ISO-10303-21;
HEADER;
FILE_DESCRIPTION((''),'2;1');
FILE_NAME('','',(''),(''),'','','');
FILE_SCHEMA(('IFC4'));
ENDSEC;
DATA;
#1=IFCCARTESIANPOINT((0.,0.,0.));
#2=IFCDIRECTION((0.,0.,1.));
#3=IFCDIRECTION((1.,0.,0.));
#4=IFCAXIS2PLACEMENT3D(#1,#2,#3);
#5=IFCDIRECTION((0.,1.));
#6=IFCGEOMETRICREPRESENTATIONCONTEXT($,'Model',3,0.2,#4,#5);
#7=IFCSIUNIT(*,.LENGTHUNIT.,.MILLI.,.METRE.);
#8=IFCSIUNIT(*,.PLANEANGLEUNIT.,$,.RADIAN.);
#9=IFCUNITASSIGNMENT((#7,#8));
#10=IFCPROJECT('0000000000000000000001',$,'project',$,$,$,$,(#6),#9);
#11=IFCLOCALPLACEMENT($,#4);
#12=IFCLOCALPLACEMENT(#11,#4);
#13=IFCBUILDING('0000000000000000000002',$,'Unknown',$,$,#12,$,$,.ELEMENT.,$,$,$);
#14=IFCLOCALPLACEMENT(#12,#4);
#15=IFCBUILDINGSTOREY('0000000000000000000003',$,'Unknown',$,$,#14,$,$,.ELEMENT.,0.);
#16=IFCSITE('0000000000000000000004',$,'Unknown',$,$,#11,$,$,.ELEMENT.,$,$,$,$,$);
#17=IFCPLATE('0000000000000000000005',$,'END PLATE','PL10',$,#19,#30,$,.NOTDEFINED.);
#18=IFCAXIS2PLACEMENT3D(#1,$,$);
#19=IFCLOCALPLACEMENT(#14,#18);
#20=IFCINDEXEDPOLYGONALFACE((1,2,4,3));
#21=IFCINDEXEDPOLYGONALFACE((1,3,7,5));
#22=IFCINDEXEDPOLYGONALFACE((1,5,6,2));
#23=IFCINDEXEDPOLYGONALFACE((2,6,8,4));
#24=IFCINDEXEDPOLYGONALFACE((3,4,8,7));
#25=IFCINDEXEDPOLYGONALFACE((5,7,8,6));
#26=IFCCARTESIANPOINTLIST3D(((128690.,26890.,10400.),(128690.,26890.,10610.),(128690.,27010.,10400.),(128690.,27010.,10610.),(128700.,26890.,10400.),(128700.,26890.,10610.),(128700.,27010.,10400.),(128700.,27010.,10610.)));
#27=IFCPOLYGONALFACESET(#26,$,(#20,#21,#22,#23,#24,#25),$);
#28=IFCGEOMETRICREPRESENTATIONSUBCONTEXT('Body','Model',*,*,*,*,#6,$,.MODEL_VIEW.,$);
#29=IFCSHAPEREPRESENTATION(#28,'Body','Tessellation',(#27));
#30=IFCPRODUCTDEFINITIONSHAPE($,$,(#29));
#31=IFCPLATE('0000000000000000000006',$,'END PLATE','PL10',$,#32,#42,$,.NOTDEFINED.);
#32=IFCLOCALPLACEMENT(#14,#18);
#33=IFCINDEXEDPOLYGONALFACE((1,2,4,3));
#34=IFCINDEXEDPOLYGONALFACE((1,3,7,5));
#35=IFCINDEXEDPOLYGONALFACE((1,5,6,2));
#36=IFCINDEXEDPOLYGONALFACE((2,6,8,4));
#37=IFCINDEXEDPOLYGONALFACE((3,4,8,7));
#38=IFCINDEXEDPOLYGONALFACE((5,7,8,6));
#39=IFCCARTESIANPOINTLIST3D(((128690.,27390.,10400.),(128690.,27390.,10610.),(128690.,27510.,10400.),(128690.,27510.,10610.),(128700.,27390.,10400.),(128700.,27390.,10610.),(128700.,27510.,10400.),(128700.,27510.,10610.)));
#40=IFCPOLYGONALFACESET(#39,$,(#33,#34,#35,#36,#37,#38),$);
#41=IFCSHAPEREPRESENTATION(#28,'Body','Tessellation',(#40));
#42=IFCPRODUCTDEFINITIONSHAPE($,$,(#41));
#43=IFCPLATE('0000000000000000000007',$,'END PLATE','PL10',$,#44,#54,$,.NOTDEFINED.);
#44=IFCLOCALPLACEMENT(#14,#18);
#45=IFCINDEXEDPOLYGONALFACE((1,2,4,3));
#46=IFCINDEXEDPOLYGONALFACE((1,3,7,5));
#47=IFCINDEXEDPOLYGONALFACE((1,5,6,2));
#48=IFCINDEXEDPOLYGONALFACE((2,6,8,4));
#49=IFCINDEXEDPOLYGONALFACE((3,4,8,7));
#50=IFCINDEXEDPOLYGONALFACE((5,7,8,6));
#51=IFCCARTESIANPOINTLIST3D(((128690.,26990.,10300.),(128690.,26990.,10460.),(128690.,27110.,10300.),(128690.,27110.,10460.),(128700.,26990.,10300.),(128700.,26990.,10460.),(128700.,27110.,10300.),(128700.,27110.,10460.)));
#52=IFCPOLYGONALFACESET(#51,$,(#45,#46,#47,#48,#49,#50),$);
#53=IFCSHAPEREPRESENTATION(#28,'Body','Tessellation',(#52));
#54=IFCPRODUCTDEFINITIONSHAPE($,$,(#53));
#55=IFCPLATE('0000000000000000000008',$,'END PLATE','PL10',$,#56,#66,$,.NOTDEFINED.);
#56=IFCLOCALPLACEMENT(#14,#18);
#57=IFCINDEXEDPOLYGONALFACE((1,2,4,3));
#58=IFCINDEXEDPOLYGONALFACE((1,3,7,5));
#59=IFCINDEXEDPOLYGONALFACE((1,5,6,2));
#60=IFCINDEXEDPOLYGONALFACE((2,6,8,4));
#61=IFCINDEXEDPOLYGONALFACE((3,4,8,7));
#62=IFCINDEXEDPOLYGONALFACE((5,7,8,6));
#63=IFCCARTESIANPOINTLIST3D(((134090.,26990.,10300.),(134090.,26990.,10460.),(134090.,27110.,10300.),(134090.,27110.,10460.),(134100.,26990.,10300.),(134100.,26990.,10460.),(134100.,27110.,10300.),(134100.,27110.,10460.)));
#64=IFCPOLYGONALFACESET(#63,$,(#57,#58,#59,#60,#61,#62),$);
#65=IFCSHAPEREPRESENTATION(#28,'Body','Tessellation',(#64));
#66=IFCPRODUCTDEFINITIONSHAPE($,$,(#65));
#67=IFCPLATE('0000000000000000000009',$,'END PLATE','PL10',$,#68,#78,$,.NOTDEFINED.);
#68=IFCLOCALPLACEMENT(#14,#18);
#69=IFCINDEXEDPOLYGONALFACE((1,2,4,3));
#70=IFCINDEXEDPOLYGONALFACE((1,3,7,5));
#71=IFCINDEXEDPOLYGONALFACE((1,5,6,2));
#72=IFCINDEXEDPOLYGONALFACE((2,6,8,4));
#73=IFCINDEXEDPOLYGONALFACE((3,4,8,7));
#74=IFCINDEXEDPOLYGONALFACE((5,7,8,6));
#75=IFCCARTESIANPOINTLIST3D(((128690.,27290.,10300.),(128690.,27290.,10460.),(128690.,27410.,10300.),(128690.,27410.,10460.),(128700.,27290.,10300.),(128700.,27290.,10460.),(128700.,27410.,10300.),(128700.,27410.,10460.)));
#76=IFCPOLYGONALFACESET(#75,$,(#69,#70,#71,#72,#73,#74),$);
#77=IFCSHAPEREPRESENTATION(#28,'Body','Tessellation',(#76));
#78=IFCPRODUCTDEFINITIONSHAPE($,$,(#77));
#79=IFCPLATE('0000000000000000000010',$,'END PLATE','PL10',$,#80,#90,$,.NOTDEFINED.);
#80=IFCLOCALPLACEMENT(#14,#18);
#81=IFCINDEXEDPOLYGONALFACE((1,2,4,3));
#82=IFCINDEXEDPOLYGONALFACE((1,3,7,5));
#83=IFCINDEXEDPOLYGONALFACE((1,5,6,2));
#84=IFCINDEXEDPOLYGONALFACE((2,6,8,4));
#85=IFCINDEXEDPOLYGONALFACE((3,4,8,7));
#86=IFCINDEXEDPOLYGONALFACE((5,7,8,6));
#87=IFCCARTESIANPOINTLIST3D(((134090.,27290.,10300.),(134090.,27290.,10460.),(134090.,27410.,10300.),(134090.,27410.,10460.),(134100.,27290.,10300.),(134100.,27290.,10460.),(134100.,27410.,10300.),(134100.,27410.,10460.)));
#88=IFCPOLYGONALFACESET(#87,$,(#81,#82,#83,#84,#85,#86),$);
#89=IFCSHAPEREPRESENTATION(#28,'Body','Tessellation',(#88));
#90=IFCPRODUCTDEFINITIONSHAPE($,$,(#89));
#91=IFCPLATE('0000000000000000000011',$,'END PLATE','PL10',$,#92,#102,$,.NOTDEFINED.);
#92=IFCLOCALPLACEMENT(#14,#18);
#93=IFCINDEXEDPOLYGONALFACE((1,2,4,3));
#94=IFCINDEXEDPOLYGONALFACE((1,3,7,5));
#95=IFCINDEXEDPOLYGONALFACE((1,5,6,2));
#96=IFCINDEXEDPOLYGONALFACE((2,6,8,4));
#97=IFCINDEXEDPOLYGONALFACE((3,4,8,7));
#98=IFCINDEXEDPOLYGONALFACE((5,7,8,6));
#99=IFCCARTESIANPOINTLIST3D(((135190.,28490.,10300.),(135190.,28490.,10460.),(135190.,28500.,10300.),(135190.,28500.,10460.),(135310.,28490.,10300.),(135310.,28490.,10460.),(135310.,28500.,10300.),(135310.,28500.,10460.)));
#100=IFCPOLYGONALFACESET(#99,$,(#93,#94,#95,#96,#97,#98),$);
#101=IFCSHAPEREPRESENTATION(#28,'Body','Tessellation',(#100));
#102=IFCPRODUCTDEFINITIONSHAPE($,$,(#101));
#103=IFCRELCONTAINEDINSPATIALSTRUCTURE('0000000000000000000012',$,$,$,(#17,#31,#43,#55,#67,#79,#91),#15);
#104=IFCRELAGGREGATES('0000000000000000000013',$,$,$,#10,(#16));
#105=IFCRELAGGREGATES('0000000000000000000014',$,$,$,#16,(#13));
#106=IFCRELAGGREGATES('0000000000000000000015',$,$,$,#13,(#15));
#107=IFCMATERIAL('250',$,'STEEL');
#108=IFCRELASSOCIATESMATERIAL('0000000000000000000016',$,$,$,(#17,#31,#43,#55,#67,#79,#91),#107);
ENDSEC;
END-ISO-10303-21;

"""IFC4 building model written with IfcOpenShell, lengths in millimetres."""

from ifc_helpers import new_model, si_unit, direction, frame, origin_with_axes, place, context, subcontext, project, spatial, line, indexed_curve, outline, extrude, material, element, save


model = new_model("IFC4")

# Units and contexts
model_context = context("Model", 3, precision=0.2, world=origin_with_axes(), true_north=direction((0.0, 1.0)))
body_context = subcontext(model_context, "Body", "Model", "MODEL_VIEW")
ifc_project = project(units=[si_unit("LENGTHUNIT", "METRE", prefix="MILLI"), si_unit("PLANEANGLEUNIT", "RADIAN")], contexts=[model_context])

# Site, building, storey
site_placement = place(None, origin_with_axes())
site = spatial("IfcSite", under=ifc_project, at=site_placement, Name="Unknown", CompositionType="ELEMENT")
building_placement = place(site_placement, origin_with_axes())
building = spatial("IfcBuilding", under=site, at=building_placement, Name="Unknown", CompositionType="ELEMENT")
storey_placement = place(building_placement, origin_with_axes())
storey = spatial("IfcBuildingStorey", under=building, at=storey_placement, Name="Unknown", CompositionType="ELEMENT", Elevation=0.0)

# Plates
ifc_material_1 = material(Name="250", Category="STEEL")
for number, where, z_axis, x_axis, name in (
    (1, (128695.0, 27010.0, 10400.0), (-1.0, 0.0, 0.0), (0.0, -1.0, 0.0), "END PLATE"),
    (2, (128695.0, 27510.0, 10400.0), (-1.0, 0.0, 0.0), (0.0, -1.0, 0.0), "END PLATE"),
):
    element("IfcPlate", number, at=place(storey_placement, frame(where, z_axis=z_axis, x_axis=x_axis)), inside=storey, material=ifc_material_1, Name=name, Description="PL10", PredefinedType="NOTDEFINED", context=body_context, shape_type="SolidModel", body=[
        extrude(outline(indexed_curve([(0.0, 0.0), (120.0, 0.0), (120.0, 210.0), (0.0, 210.0)], segments=[line(1, 2, 3, 4, 1)])), frame((0.0, 0.0, 5.0), z_axis=(0.0, 0.0, 1.0), x_axis=(1.0, 0.0, 0.0)), (0.0, 0.0, -1.0), 10.0),
    ])
for number, where, z_axis, x_axis, name in (
    (3, (128695.0, 27110.0, 10300.0), (-1.0, 0.0, 0.0), (0.0, -1.0, 0.0), "END PLATE"),
    (4, (134095.0, 27110.0, 10300.0), (-1.0, 0.0, 0.0), (0.0, -1.0, 0.0), "END PLATE"),
    (5, (128695.0, 27410.0, 10300.0), (-1.0, 0.0, 0.0), (0.0, -1.0, 0.0), "END PLATE"),
    (6, (134095.0, 27410.0, 10300.0), (-1.0, 0.0, 0.0), (0.0, -1.0, 0.0), "END PLATE"),
    (7, (135190.0, 28495.0, 10300.0), (0.0, -1.0, 0.0), (1.0, 0.0, 0.0), "END PLATE"),
):
    element("IfcPlate", number, at=place(storey_placement, frame(where, z_axis=z_axis, x_axis=x_axis)), inside=storey, material=ifc_material_1, Name=name, Description="PL10", PredefinedType="NOTDEFINED", context=body_context, shape_type="SolidModel", body=[
        extrude(outline(indexed_curve([(0.0, 0.0), (120.0, 0.0), (120.0, 160.0), (0.0, 160.0)], segments=[line(1, 2, 3, 4, 1)])), frame((0.0, 0.0, 5.0), z_axis=(0.0, 0.0, 1.0), x_axis=(1.0, 0.0, 0.0)), (0.0, 0.0, -1.0), 10.0),
    ])

save(model, "model.ifc")
